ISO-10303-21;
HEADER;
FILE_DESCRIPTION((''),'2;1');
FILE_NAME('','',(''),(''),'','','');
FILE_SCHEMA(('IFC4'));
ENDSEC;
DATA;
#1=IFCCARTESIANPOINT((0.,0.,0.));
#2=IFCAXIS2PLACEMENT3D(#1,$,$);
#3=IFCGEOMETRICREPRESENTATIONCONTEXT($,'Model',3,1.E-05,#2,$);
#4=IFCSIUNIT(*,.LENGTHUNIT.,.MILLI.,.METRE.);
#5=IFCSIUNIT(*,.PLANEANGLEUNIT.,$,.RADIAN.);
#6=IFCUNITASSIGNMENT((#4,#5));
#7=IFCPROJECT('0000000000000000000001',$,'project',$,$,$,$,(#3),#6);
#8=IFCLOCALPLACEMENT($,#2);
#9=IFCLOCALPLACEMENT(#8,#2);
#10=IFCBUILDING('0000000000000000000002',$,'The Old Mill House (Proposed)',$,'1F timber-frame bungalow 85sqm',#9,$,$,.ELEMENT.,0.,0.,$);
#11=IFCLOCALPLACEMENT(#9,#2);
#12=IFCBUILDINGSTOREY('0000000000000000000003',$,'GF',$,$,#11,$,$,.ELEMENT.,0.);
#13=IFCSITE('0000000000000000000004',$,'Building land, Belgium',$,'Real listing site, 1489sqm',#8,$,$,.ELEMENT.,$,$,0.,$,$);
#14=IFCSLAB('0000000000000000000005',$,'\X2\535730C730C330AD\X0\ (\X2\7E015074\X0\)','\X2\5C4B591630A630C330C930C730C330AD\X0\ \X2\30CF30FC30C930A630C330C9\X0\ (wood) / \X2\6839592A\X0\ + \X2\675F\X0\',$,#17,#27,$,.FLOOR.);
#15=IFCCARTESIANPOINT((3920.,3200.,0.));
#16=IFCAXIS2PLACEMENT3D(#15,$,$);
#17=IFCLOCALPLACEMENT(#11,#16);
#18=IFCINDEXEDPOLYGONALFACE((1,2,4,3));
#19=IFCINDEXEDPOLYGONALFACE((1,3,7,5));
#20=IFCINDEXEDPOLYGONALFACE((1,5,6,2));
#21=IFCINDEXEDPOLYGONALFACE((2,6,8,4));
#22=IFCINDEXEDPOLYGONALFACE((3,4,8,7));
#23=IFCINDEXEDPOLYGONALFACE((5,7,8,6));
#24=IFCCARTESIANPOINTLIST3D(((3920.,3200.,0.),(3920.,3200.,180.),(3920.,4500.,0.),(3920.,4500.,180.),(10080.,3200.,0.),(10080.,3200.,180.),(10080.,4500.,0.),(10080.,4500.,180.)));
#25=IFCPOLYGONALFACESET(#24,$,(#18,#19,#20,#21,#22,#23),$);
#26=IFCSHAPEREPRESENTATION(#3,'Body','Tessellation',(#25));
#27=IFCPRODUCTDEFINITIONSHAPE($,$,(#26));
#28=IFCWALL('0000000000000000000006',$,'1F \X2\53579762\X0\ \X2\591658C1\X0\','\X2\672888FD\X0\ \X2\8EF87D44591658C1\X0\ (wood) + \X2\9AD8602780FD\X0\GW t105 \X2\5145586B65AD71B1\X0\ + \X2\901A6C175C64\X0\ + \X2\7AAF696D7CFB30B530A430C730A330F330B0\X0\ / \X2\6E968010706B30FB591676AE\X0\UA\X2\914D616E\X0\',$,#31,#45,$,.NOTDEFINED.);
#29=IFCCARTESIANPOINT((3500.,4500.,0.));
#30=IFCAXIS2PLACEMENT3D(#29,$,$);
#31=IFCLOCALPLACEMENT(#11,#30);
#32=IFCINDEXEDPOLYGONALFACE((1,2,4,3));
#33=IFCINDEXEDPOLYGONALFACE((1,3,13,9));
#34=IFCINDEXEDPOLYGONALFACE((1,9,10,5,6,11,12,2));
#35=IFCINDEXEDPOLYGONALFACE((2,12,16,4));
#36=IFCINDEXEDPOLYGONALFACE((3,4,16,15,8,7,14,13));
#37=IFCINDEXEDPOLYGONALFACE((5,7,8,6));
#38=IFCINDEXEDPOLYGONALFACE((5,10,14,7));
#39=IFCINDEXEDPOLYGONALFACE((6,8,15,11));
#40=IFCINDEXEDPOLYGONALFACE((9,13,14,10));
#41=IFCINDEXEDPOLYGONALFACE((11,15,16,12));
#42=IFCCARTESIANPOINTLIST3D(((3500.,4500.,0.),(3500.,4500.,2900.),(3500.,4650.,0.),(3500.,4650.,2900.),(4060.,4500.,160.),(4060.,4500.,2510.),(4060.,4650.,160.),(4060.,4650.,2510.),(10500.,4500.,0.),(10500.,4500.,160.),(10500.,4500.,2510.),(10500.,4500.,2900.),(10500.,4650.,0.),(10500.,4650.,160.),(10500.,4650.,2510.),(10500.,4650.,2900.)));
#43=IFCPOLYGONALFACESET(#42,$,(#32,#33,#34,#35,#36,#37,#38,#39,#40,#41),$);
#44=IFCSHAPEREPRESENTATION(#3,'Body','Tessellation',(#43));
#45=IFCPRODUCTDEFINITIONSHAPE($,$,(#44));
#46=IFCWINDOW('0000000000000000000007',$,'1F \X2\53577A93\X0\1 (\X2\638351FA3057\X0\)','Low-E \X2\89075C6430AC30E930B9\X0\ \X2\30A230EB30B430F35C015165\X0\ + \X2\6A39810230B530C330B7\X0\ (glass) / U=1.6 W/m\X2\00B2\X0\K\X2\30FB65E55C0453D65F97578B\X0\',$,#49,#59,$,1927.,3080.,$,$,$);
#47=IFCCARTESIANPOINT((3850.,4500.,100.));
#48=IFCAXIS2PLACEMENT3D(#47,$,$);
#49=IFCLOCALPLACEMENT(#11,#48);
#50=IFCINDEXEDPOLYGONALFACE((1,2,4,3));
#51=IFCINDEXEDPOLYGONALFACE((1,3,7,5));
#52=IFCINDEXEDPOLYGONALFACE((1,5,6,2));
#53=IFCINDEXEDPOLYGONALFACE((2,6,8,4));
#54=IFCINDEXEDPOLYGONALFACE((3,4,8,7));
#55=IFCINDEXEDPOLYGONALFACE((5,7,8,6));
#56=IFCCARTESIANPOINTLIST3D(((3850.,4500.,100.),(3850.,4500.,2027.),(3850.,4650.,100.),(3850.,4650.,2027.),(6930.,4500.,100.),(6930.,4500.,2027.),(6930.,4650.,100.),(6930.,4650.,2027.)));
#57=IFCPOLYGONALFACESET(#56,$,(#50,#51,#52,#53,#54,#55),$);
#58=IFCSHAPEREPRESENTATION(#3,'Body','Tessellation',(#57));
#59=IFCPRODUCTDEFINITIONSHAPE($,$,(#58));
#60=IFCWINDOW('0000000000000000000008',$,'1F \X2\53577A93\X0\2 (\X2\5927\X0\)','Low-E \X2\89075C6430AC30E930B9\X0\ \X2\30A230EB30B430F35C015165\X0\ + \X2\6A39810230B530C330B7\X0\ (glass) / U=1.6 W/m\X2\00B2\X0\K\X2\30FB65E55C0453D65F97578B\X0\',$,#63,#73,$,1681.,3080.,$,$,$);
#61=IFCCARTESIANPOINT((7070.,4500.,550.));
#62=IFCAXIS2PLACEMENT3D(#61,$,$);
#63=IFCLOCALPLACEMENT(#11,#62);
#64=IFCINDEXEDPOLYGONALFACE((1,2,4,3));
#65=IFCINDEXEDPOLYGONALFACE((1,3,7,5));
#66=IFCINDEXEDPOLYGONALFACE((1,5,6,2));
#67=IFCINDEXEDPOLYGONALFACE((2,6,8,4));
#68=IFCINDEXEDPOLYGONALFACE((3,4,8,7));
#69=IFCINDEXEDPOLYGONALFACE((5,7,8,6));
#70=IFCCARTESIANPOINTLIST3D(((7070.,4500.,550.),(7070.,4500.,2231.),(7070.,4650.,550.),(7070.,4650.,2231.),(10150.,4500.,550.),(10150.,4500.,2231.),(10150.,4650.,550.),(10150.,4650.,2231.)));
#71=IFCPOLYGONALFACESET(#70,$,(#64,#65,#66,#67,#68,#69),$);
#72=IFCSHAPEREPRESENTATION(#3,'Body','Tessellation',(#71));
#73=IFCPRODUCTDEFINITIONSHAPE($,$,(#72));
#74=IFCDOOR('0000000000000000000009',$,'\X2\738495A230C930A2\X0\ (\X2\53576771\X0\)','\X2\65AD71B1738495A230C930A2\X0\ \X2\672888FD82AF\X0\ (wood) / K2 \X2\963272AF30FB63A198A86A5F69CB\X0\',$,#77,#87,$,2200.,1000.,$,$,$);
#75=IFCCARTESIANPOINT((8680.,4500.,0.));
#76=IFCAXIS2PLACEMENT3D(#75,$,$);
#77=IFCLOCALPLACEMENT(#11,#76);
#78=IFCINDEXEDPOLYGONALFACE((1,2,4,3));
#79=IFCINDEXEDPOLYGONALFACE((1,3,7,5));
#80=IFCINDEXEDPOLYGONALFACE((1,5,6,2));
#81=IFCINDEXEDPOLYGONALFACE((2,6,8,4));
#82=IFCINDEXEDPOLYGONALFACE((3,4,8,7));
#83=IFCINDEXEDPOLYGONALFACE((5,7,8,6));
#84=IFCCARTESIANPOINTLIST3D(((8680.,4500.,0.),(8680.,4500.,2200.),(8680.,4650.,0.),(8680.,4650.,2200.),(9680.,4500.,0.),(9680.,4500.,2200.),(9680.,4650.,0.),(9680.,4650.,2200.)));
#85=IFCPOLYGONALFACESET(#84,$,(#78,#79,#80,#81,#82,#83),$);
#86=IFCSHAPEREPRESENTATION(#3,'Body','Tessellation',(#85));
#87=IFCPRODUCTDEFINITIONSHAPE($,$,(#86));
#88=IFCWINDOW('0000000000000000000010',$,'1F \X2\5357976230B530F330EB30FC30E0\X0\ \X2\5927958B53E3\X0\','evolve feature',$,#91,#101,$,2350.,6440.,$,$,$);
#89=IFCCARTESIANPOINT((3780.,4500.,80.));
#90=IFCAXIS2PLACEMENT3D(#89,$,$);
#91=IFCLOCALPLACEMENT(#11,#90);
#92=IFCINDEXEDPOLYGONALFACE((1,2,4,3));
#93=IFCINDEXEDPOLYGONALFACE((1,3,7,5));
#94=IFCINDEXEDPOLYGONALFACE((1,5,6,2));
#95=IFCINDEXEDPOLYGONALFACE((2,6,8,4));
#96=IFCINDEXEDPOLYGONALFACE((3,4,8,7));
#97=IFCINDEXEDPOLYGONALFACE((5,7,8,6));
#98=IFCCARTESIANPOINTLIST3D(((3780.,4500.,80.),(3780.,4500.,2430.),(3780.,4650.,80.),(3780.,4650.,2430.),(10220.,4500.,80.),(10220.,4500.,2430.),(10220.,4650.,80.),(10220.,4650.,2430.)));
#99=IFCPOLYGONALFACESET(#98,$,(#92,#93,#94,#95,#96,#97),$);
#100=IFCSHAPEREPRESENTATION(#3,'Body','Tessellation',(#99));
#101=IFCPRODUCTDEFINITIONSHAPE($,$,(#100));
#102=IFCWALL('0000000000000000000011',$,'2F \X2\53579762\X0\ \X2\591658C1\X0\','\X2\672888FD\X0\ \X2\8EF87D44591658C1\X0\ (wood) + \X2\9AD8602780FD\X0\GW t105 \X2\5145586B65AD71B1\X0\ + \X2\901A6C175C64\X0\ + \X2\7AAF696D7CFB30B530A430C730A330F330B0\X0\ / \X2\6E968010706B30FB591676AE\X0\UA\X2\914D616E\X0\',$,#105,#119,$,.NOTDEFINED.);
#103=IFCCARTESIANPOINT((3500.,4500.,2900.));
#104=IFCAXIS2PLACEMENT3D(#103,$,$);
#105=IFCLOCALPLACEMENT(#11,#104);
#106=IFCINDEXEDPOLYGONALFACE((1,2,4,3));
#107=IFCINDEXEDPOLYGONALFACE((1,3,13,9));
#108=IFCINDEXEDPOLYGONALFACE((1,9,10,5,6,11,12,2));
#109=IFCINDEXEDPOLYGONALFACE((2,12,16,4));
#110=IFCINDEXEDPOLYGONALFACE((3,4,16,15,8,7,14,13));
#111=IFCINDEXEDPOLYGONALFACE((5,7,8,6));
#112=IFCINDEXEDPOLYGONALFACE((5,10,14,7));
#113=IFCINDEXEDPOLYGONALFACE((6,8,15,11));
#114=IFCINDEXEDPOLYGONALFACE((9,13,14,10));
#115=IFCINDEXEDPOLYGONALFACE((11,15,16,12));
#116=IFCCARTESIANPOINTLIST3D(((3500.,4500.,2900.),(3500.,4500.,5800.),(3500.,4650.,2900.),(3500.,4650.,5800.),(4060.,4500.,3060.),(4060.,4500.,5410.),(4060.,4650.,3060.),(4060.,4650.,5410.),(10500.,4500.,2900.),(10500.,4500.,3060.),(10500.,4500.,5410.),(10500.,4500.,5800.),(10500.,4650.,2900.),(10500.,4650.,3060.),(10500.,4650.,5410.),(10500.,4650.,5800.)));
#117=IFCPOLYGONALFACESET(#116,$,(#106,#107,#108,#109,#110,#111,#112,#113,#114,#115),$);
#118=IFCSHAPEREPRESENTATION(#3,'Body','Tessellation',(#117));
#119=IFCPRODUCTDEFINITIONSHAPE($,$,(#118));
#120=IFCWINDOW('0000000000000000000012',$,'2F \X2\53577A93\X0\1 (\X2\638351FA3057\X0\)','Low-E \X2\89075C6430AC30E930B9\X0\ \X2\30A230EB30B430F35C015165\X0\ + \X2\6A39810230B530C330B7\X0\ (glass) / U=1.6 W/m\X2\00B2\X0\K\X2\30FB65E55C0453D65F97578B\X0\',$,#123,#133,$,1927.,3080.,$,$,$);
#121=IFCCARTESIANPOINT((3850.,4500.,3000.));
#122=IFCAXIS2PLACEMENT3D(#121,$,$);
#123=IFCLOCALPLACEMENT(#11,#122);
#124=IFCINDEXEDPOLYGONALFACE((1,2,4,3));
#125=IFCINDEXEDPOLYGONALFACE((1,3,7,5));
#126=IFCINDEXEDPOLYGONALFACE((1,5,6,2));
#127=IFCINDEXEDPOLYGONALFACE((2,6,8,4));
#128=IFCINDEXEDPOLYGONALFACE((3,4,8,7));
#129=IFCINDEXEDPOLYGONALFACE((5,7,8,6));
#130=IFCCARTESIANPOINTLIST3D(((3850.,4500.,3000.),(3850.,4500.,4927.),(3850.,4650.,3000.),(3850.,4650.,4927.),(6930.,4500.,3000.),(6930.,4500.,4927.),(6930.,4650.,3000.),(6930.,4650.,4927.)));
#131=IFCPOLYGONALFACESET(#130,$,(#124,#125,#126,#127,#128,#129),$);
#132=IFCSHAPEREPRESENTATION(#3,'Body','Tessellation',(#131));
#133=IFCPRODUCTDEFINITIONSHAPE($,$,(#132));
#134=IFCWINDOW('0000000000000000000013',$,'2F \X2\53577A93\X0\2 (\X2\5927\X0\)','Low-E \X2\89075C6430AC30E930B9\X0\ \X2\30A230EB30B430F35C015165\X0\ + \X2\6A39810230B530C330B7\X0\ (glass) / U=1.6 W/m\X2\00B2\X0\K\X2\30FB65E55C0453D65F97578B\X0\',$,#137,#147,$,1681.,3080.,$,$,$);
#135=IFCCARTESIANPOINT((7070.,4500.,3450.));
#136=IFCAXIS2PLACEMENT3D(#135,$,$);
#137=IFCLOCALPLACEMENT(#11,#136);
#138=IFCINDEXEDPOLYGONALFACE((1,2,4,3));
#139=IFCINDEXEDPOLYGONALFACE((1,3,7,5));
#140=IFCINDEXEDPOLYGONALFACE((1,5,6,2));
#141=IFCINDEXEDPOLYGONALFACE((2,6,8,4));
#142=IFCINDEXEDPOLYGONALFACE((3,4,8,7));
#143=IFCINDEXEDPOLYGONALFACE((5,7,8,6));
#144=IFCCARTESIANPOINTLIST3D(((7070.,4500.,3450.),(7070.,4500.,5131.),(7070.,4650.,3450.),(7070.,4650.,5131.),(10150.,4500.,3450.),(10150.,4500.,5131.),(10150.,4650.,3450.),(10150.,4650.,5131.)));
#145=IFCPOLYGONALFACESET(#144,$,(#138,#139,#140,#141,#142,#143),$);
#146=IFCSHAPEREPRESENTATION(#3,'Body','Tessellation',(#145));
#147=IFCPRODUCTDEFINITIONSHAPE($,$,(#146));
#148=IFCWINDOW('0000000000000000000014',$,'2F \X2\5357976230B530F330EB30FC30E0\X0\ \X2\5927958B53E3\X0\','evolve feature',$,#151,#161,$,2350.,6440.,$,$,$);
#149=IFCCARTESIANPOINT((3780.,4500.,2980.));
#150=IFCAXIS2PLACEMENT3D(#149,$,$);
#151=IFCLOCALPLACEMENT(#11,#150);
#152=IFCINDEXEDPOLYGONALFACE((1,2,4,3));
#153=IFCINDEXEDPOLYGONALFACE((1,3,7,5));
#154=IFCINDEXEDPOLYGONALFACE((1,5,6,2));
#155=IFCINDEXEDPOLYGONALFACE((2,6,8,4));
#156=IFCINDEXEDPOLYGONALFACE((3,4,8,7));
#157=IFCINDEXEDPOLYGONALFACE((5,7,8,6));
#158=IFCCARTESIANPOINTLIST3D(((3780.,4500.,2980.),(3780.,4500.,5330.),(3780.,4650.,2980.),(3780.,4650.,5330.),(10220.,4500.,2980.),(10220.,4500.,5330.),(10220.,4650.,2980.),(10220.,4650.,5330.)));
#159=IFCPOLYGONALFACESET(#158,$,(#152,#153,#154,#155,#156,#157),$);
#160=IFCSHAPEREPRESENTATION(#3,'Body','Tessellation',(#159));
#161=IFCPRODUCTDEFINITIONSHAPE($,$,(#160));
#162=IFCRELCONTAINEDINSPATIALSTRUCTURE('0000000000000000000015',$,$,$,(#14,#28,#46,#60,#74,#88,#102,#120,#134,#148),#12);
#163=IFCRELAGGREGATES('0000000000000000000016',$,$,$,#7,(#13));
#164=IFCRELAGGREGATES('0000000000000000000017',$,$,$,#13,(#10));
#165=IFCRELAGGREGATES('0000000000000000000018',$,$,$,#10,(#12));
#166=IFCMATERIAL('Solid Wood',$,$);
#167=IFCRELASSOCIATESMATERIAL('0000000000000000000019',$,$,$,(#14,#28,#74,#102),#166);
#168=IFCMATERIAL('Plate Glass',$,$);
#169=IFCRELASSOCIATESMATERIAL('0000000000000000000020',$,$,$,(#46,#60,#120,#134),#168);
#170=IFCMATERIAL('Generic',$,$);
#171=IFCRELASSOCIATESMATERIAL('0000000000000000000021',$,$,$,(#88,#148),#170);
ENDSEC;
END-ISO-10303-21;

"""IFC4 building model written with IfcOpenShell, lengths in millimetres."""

from ifc_helpers import new_model, si_unit, frame, frame_2d, origin, place, context, project, spatial, rectangle, extrude, material, element, fill, save


model = new_model("IFC4")

# Units and contexts
model_context = context("Model", 3, precision=1e-05, world=origin())
ifc_project = project(units=[si_unit("LENGTHUNIT", "METRE", prefix="MILLI"), si_unit("PLANEANGLEUNIT", "RADIAN")], contexts=[model_context])

# Site, building, storey
site_placement = place(None, origin())
site = spatial("IfcSite", under=ifc_project, at=site_placement, Name="Building land, Belgium", ObjectType="Real listing site, 1489sqm", CompositionType="ELEMENT", RefElevation=0.0)
building_placement = place(site_placement, origin())
building = spatial("IfcBuilding", under=site, at=building_placement, Name="The Old Mill House (Proposed)", ObjectType="1F timber-frame bungalow 85sqm", CompositionType="ELEMENT", ElevationOfRefHeight=0.0, ElevationOfTerrain=0.0)
storey_placement = place(building_placement, origin())
storey = spatial("IfcBuildingStorey", under=building, at=storey_placement, Name="GF", CompositionType="ELEMENT", Elevation=0.0)

# Slab
ifc_material_1 = material(Name="Solid Wood")
slab_1_placement = place(storey_placement, frame((3920.0, 3200.0, 0.0)))
element("IfcSlab", 1, at=slab_1_placement, inside=storey, material=ifc_material_1, Name="南デッキ (縁側)", Description="屋外ウッドデッキ ハードウッド (wood) / 根太 + 束", PredefinedType="FLOOR", context=model_context, shape_type="SweptSolid", body=[
    extrude(rectangle(XDim=6160.0, YDim=1300.0, at=frame_2d((3080.0, 650.0))), frame((3920.0, 3200.0, 0.0)), (0.0, 0.0, 1.0), 180.0),
])
ifc_material_2 = material(Name="Generic")

# Wall, openings, windows, door
wall_1_placement = place(storey_placement, frame((3500.0, 4500.0, 0.0)))
wall_1 = element("IfcWall", 2, at=wall_1_placement, inside=storey, material=ifc_material_1, Name="1F 南面 外壁", Description="木製 軸組外壁 (wood) + 高性能GW t105 充填断熱 + 通気層 + 窯業系サイディング / 準耐火・外皮UA配慮", PredefinedType="NOTDEFINED", context=model_context, shape_type="SweptSolid", body=[
    extrude(rectangle(XDim=7000.0, YDim=150.0, at=frame_2d((3500.0, 75.0))), frame((3500.0, 4500.0, 0.0)), (0.0, 0.0, 1.0), 2900.0),
])
opening_1_placement = place(storey_placement, frame((3850.0, 4500.0, 100.0)))
opening_1 = element("IfcOpeningElement", 3, at=opening_1_placement, cuts=wall_1, PredefinedType="NOTDEFINED", context=model_context, shape_type="SweptSolid", body=[
    extrude(rectangle(XDim=3080.0, YDim=150.0, at=frame_2d((1540.0, 75.0))), frame((3850.0, 4500.0, 100.0)), (0.0, 0.0, 1.0), 1927.0),
])
opening_2_placement = place(storey_placement, frame((7070.0, 4500.0, 550.0)))
opening_2 = element("IfcOpeningElement", 4, at=opening_2_placement, cuts=wall_1, PredefinedType="NOTDEFINED", context=model_context, shape_type="SweptSolid", body=[
    extrude(rectangle(XDim=3080.0, YDim=150.0, at=frame_2d((1540.0, 75.0))), frame((7070.0, 4500.0, 550.0)), (0.0, 0.0, 1.0), 1681.0),
])
opening_3_placement = place(storey_placement, frame((8680.0, 4500.0, 0.0)))
opening_3 = element("IfcOpeningElement", 5, at=opening_3_placement, cuts=wall_1, PredefinedType="NOTDEFINED", context=model_context, shape_type="SweptSolid", body=[
    extrude(rectangle(XDim=1000.0, YDim=150.0, at=frame_2d((500.0, 75.0))), frame((8680.0, 4500.0, 0.0)), (0.0, 0.0, 1.0), 2200.0),
])
opening_4_placement = place(storey_placement, frame((3780.0, 4500.0, 80.0)))
opening_4 = element("IfcOpeningElement", 6, at=opening_4_placement, cuts=wall_1, PredefinedType="NOTDEFINED", context=model_context, shape_type="SweptSolid", body=[
    extrude(rectangle(XDim=6440.0, YDim=150.0, at=frame_2d((3220.0, 75.0))), frame((3780.0, 4500.0, 80.0)), (0.0, 0.0, 1.0), 2350.0),
])
ifc_material_3 = material(Name="Plate Glass")
window_1_placement = place(storey_placement, frame((3850.0, 4500.0, 100.0)))
window_1 = element("IfcWindow", 7, at=window_1_placement, inside=storey, material=ifc_material_3, Name="1F 南窓1 (掃出し)", Description="Low-E 複層ガラス アルゴン封入 + 樹脂サッシ (glass) / U=1.6 W/m²K・日射取得型", OverallHeight=1927.0, OverallWidth=3080.0, context=model_context, shape_type="SweptSolid", body=[
    extrude(rectangle(XDim=3080.0, YDim=150.0, at=frame_2d((1540.0, 75.0))), frame((3850.0, 4500.0, 100.0)), (0.0, 0.0, 1.0), 1927.0),
])
fill(opening_1, window_1)
window_2_placement = place(storey_placement, frame((7070.0, 4500.0, 550.0)))
window_2 = element("IfcWindow", 8, at=window_2_placement, inside=storey, material=ifc_material_3, Name="1F 南窓2 (大)", Description="Low-E 複層ガラス アルゴン封入 + 樹脂サッシ (glass) / U=1.6 W/m²K・日射取得型", OverallHeight=1681.0, OverallWidth=3080.0, context=model_context, shape_type="SweptSolid", body=[
    extrude(rectangle(XDim=3080.0, YDim=150.0, at=frame_2d((1540.0, 75.0))), frame((7070.0, 4500.0, 550.0)), (0.0, 0.0, 1.0), 1681.0),
])
fill(opening_2, window_2)
door_placement = place(storey_placement, frame((8680.0, 4500.0, 0.0)))
door = element("IfcDoor", 9, at=door_placement, inside=storey, material=ifc_material_1, Name="玄関ドア (南東)", Description="断熱玄関ドア 木製芯 (wood) / K2 防犯・採風機構", OverallHeight=2200.0, OverallWidth=1000.0, context=model_context, shape_type="SweptSolid", body=[
    extrude(rectangle(XDim=1000.0, YDim=150.0, at=frame_2d((500.0, 75.0))), frame((8680.0, 4500.0, 0.0)), (0.0, 0.0, 1.0), 2200.0),
])
fill(opening_3, door)
window_3_placement = place(storey_placement, frame((3780.0, 4500.0, 80.0)))
window_3 = element("IfcWindow", 10, at=window_3_placement, inside=storey, material=ifc_material_2, Name="1F 南面サンルーム 大開口", Description="evolve feature", OverallHeight=2350.0, OverallWidth=6440.0, context=model_context, shape_type="SweptSolid", body=[
    extrude(rectangle(XDim=6440.0, YDim=150.0, at=frame_2d((3220.0, 75.0))), frame((3780.0, 4500.0, 80.0)), (0.0, 0.0, 1.0), 2350.0),
])
fill(opening_4, window_3)

# Wall, openings, windows
wall_2_placement = place(storey_placement, frame((3500.0, 4500.0, 2900.0)))
wall_2 = element("IfcWall", 11, at=wall_2_placement, inside=storey, material=ifc_material_1, Name="2F 南面 外壁", Description="木製 軸組外壁 (wood) + 高性能GW t105 充填断熱 + 通気層 + 窯業系サイディング / 準耐火・外皮UA配慮", PredefinedType="NOTDEFINED", context=model_context, shape_type="SweptSolid", body=[
    extrude(rectangle(XDim=7000.0, YDim=150.0, at=frame_2d((3500.0, 75.0))), frame((3500.0, 4500.0, 2900.0)), (0.0, 0.0, 1.0), 2900.0),
])
opening_5_placement = place(storey_placement, frame((3850.0, 4500.0, 3000.0)))
opening_5 = element("IfcOpeningElement", 12, at=opening_5_placement, cuts=wall_2, PredefinedType="NOTDEFINED", context=model_context, shape_type="SweptSolid", body=[
    extrude(rectangle(XDim=3080.0, YDim=150.0, at=frame_2d((1540.0, 75.0))), frame((3850.0, 4500.0, 3000.0)), (0.0, 0.0, 1.0), 1927.0),
])
opening_6_placement = place(storey_placement, frame((7070.0, 4500.0, 3450.0)))
opening_6 = element("IfcOpeningElement", 13, at=opening_6_placement, cuts=wall_2, PredefinedType="NOTDEFINED", context=model_context, shape_type="SweptSolid", body=[
    extrude(rectangle(XDim=3080.0, YDim=150.0, at=frame_2d((1540.0, 75.0))), frame((7070.0, 4500.0, 3450.0)), (0.0, 0.0, 1.0), 1681.0),
])
opening_7_placement = place(storey_placement, frame((3780.0, 4500.0, 2980.0)))
opening_7 = element("IfcOpeningElement", 14, at=opening_7_placement, cuts=wall_2, PredefinedType="NOTDEFINED", context=model_context, shape_type="SweptSolid", body=[
    extrude(rectangle(XDim=6440.0, YDim=150.0, at=frame_2d((3220.0, 75.0))), frame((3780.0, 4500.0, 2980.0)), (0.0, 0.0, 1.0), 2350.0),
])
window_4_placement = place(storey_placement, frame((3850.0, 4500.0, 3000.0)))
window_4 = element("IfcWindow", 15, at=window_4_placement, inside=storey, material=ifc_material_3, Name="2F 南窓1 (掃出し)", Description="Low-E 複層ガラス アルゴン封入 + 樹脂サッシ (glass) / U=1.6 W/m²K・日射取得型", OverallHeight=1927.0, OverallWidth=3080.0, context=model_context, shape_type="SweptSolid", body=[
    extrude(rectangle(XDim=3080.0, YDim=150.0, at=frame_2d((1540.0, 75.0))), frame((3850.0, 4500.0, 3000.0)), (0.0, 0.0, 1.0), 1927.0),
])
fill(opening_5, window_4)
window_5_placement = place(storey_placement, frame((7070.0, 4500.0, 3450.0)))
window_5 = element("IfcWindow", 16, at=window_5_placement, inside=storey, material=ifc_material_3, Name="2F 南窓2 (大)", Description="Low-E 複層ガラス アルゴン封入 + 樹脂サッシ (glass) / U=1.6 W/m²K・日射取得型", OverallHeight=1681.0, OverallWidth=3080.0, context=model_context, shape_type="SweptSolid", body=[
    extrude(rectangle(XDim=3080.0, YDim=150.0, at=frame_2d((1540.0, 75.0))), frame((7070.0, 4500.0, 3450.0)), (0.0, 0.0, 1.0), 1681.0),
])
fill(opening_6, window_5)
window_6_placement = place(storey_placement, frame((3780.0, 4500.0, 2980.0)))
window_6 = element("IfcWindow", 17, at=window_6_placement, inside=storey, material=ifc_material_2, Name="2F 南面サンルーム 大開口", Description="evolve feature", OverallHeight=2350.0, OverallWidth=6440.0, context=model_context, shape_type="SweptSolid", body=[
    extrude(rectangle(XDim=6440.0, YDim=150.0, at=frame_2d((3220.0, 75.0))), frame((3780.0, 4500.0, 2980.0)), (0.0, 0.0, 1.0), 2350.0),
])
fill(opening_7, window_6)

save(model, "model.ifc")
